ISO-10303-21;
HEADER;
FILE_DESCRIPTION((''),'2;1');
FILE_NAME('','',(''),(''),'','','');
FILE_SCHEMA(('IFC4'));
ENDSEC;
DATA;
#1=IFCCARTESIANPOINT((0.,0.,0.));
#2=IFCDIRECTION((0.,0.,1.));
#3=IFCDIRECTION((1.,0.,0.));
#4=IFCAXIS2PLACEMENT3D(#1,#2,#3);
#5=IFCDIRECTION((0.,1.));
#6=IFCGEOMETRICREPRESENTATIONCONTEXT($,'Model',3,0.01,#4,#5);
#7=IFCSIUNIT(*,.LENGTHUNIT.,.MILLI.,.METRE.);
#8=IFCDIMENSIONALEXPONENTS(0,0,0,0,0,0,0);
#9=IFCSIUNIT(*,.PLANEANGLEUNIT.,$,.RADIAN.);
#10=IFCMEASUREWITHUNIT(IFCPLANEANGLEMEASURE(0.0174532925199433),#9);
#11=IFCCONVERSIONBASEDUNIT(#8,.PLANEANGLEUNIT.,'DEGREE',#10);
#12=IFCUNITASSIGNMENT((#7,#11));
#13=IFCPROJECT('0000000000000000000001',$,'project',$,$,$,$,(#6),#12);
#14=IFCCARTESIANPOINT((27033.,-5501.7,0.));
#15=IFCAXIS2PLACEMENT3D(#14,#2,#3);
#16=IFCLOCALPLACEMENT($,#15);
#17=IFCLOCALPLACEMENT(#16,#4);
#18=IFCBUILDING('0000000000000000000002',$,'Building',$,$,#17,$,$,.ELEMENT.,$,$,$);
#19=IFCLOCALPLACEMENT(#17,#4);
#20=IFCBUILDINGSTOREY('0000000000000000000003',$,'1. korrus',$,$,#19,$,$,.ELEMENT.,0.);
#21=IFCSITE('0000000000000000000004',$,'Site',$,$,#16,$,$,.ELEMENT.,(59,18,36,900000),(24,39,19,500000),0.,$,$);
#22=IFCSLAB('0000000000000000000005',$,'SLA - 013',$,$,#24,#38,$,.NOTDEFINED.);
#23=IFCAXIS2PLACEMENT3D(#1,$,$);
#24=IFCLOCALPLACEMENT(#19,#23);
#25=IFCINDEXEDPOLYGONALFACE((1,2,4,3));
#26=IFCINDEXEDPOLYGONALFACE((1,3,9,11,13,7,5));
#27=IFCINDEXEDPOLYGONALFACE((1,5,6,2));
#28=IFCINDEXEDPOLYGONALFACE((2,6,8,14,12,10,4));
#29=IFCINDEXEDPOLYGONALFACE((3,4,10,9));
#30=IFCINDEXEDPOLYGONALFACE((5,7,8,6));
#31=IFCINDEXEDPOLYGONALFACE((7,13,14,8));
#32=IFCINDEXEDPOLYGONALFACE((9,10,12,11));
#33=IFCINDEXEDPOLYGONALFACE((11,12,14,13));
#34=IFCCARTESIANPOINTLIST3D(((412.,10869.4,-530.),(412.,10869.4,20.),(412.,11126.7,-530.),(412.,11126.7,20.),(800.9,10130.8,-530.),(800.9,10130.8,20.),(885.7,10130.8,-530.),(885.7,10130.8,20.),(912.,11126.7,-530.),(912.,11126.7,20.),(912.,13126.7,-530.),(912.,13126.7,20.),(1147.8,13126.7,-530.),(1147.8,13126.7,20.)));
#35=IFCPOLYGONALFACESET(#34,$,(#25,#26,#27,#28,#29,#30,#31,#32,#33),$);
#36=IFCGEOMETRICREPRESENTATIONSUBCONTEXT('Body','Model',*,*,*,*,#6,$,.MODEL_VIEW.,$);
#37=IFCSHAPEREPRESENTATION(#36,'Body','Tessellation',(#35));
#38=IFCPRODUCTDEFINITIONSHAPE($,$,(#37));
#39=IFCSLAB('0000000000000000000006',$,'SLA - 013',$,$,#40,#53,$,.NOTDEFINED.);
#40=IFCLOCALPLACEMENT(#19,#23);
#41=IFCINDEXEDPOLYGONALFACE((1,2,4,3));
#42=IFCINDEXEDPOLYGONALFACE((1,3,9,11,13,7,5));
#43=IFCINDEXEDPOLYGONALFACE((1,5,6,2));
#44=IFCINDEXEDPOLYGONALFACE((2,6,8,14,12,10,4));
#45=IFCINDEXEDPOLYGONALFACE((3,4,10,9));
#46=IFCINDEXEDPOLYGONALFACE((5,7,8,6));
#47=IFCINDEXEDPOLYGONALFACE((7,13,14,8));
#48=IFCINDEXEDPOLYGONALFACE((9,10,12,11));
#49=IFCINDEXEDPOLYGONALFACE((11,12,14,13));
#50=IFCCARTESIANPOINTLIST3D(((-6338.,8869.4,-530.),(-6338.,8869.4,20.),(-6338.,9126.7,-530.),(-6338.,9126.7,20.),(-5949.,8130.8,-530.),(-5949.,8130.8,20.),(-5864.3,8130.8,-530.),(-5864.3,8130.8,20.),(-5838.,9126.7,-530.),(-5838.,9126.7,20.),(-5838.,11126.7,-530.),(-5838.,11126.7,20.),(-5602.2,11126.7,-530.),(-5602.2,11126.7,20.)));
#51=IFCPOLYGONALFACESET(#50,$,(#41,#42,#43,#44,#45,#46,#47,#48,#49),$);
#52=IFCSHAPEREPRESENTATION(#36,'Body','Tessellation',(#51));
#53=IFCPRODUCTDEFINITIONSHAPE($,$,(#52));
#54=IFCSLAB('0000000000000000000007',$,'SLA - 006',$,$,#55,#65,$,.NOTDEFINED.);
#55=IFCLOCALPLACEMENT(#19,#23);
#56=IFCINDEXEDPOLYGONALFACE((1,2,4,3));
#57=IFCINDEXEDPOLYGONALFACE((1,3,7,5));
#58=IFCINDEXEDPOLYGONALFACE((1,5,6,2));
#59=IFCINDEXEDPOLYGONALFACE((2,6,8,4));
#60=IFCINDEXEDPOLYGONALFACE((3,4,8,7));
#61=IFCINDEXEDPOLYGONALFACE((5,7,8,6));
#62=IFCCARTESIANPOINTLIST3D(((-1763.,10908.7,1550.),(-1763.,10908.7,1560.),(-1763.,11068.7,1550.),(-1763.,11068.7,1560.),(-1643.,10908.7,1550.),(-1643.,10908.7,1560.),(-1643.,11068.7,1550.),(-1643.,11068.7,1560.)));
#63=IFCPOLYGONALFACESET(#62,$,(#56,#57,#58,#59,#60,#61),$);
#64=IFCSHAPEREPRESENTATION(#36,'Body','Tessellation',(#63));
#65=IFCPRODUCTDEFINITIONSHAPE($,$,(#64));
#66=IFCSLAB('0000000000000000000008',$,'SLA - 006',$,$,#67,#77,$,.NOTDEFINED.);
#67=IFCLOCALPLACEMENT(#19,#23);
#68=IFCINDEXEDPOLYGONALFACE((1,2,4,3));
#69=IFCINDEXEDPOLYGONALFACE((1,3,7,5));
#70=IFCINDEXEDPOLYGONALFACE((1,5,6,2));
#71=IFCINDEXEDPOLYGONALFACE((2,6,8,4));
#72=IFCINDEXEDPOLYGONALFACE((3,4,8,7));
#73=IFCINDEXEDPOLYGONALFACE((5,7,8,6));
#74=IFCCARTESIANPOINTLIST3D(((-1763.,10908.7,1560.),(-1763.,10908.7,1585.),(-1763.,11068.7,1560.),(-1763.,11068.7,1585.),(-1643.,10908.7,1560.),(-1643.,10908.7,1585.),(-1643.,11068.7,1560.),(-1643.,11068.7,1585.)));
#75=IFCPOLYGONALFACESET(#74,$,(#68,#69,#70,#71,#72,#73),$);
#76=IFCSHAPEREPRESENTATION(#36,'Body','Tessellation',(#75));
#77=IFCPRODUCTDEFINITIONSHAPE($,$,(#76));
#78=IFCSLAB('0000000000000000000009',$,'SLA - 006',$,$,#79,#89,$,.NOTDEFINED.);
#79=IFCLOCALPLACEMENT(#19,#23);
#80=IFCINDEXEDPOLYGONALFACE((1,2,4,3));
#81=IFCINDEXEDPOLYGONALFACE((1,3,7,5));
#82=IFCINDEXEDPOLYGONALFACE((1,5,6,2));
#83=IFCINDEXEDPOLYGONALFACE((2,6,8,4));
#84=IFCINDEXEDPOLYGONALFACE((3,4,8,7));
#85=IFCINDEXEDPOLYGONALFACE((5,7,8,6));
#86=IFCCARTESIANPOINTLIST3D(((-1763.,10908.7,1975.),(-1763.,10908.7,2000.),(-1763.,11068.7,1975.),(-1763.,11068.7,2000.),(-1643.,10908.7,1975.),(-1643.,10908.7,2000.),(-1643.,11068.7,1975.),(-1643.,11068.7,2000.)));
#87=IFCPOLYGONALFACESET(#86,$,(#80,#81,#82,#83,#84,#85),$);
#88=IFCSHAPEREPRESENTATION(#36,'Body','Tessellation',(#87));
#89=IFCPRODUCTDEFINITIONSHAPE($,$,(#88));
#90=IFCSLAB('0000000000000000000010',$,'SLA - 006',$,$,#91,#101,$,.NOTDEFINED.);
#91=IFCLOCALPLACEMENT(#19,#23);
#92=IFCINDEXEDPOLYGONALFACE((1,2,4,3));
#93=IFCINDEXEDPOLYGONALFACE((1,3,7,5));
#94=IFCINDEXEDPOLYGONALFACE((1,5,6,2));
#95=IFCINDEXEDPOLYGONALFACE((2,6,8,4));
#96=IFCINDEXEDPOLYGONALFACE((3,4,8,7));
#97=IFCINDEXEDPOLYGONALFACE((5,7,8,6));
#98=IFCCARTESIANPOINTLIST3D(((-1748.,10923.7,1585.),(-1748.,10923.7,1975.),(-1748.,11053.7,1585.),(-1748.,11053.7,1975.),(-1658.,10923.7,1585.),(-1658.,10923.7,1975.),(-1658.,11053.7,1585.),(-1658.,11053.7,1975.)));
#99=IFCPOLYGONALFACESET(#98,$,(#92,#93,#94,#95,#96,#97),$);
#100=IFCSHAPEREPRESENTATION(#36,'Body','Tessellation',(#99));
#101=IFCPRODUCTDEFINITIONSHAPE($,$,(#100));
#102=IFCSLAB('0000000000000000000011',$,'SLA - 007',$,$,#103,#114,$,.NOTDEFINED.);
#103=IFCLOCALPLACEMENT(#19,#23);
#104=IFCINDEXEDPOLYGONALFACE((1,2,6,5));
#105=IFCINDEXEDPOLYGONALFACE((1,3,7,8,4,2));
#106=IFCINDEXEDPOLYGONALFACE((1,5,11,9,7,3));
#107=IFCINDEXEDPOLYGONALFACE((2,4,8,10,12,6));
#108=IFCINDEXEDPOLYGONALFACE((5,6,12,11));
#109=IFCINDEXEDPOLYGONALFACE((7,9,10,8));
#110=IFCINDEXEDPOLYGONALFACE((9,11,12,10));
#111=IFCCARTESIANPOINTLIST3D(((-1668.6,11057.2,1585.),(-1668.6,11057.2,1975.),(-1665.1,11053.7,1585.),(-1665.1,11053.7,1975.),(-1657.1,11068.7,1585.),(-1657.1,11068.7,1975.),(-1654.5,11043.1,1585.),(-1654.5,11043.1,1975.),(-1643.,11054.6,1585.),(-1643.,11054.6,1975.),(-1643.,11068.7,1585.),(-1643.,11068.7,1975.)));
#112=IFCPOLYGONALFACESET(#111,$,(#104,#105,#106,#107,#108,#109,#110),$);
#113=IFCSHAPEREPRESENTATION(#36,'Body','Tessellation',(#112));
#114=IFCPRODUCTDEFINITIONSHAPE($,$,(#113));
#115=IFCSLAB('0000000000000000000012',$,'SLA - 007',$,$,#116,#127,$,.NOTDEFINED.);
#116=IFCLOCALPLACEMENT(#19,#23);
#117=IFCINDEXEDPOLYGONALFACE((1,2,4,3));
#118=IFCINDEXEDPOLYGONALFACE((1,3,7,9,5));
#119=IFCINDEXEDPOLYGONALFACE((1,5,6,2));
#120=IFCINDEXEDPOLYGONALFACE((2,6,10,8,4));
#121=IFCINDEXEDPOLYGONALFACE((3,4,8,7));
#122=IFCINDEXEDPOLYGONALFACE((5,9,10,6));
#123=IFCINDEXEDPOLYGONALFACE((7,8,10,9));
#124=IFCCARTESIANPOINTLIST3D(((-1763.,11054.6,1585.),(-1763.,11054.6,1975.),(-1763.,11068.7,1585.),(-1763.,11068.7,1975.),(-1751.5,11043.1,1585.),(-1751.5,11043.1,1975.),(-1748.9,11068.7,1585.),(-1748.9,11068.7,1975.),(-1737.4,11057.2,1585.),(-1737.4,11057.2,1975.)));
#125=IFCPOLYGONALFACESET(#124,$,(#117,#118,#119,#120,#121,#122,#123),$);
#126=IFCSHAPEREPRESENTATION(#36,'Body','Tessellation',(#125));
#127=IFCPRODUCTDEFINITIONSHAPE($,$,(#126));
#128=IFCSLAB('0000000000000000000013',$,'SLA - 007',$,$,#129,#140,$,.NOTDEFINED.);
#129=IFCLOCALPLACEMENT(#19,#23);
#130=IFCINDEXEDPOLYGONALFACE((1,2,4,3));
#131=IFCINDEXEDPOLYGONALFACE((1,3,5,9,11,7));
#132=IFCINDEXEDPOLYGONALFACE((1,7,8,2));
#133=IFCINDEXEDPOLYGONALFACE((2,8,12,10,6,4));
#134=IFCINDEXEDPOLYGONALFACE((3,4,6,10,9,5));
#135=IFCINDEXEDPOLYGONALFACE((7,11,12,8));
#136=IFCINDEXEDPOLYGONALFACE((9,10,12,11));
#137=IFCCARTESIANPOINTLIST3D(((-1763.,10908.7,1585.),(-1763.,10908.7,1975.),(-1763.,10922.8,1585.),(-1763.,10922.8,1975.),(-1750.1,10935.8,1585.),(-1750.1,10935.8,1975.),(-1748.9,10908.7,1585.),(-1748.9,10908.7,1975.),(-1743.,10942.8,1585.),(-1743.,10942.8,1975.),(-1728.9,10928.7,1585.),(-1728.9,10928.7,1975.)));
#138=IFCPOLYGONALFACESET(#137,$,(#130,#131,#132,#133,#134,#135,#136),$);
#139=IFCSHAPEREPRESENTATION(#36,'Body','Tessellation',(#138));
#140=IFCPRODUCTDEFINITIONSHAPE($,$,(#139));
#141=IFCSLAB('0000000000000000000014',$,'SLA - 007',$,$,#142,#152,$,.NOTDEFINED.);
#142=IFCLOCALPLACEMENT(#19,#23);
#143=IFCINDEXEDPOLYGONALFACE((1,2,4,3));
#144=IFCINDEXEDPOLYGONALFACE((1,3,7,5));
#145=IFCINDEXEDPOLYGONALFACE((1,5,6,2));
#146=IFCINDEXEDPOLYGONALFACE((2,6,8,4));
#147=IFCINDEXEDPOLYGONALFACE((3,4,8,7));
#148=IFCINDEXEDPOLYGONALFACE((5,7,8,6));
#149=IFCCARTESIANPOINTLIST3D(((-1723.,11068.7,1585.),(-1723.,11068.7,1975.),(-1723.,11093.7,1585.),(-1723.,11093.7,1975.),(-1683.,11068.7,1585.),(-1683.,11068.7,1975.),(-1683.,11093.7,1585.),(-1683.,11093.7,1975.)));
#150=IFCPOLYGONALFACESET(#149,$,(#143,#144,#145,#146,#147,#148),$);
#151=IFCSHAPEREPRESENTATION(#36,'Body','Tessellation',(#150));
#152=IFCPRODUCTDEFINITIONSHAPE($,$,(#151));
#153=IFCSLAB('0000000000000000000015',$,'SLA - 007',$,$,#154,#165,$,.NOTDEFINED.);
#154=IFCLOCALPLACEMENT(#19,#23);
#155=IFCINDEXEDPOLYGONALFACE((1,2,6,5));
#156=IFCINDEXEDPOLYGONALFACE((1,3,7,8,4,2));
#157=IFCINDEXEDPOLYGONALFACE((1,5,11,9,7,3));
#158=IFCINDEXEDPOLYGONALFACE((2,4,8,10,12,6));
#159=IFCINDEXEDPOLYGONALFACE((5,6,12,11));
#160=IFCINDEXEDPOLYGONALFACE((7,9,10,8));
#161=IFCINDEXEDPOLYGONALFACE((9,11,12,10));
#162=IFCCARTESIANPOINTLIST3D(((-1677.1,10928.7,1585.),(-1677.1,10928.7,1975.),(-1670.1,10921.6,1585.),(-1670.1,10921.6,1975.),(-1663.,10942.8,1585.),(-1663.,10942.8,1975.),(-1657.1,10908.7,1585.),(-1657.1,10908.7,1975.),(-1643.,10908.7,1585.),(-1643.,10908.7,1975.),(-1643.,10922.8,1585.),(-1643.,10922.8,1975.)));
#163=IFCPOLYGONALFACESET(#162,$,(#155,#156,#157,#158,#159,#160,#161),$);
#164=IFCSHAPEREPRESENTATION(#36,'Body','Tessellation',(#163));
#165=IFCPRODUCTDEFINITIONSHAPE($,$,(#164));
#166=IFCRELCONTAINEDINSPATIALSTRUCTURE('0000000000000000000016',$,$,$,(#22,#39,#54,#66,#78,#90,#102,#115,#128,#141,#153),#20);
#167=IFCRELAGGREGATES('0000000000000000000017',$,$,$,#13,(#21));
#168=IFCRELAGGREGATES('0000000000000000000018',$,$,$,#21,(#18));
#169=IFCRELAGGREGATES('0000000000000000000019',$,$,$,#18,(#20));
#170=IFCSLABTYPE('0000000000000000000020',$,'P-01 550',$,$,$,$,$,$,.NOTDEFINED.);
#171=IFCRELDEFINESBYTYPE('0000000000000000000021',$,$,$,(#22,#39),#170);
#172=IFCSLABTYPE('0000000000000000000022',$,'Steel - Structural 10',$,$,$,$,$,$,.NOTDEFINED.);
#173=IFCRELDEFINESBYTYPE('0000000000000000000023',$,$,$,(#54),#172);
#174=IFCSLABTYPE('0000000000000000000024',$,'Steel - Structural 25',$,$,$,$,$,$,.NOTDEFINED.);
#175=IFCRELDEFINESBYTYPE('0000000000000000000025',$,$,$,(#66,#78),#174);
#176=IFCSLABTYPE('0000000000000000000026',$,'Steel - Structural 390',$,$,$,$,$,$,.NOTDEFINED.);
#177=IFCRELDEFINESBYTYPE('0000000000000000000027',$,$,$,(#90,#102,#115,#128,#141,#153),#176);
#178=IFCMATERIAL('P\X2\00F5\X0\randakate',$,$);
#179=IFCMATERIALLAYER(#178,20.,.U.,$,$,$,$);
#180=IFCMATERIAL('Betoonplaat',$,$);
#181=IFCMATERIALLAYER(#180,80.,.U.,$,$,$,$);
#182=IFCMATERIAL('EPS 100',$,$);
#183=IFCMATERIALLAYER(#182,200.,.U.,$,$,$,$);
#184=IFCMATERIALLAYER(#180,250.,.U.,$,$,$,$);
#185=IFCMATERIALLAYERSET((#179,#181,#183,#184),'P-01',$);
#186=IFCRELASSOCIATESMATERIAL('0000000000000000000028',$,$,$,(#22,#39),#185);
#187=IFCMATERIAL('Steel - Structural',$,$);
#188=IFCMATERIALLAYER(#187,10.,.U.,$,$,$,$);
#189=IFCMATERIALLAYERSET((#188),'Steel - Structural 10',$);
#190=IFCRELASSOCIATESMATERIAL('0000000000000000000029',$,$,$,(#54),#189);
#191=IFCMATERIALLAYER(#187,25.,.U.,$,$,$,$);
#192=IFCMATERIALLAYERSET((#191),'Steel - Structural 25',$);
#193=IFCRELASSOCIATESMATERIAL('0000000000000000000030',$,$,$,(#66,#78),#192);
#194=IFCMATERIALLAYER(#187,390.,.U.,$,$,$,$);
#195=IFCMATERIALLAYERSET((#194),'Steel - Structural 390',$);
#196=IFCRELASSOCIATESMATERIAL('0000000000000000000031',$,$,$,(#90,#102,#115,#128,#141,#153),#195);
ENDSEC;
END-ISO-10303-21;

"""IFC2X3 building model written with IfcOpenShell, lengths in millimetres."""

from ifc_helpers import new_model, entity, si_unit, converted_unit, direction, frame, origin_with_axes, place, context, subcontext, project, spatial, polyline, outline, extrude, material, layer, layer_set, layer_usage, type_object, element, save


model = new_model("IFC2X3")

# Units and contexts
model_context = context("Model", 3, precision=0.01, world=origin_with_axes(), true_north=direction((0.0, 1.0)))
body_context = subcontext(model_context, "Body", "Model", "MODEL_VIEW")
ifc_project = project(units=[si_unit("LENGTHUNIT", "METRE", prefix="MILLI"), converted_unit("PLANEANGLEUNIT", "DEGREE", entity("IfcPlaneAngleMeasure", 0.0174532925199433), si_unit("PLANEANGLEUNIT", "RADIAN"), dimensions=[0, 0, 0, 0, 0, 0, 0])], contexts=[model_context])

# Site, building, storey
site_placement = place(None, frame((27033.0, -5501.7, 0.0), z_axis=(0.0, 0.0, 1.0), x_axis=(1.0, 0.0, 0.0)))
site = spatial("IfcSite", under=ifc_project, at=site_placement, Name="Site", CompositionType="ELEMENT", RefLatitude=(59, 18, 36, 900000), RefLongitude=(24, 39, 19, 500000), RefElevation=0.0)
building_placement = place(site_placement, origin_with_axes())
building = spatial("IfcBuilding", under=site, at=building_placement, Name="Building", CompositionType="ELEMENT")
storey_placement = place(building_placement, origin_with_axes())
storey = spatial("IfcBuildingStorey", under=building, at=storey_placement, Name="1. korrus", CompositionType="ELEMENT", Elevation=0.0)

# Slabs
ifc_material_1 = material(Name="Põrandakate")
ifc_layer_1 = layer(ifc_material_1, 20.0, ventilated="UNKNOWN")
ifc_material_2 = material(Name="Betoonplaat")
ifc_layer_2 = layer(ifc_material_2, 80.0, ventilated="UNKNOWN")
ifc_material_3 = material(Name="EPS 100")
ifc_layer_3 = layer(ifc_material_3, 200.0, ventilated="UNKNOWN")
ifc_layer_4 = layer(ifc_material_2, 250.0, ventilated="UNKNOWN")
ifc_layer_set_1 = layer_set([ifc_layer_1, ifc_layer_2, ifc_layer_3, ifc_layer_4], Name="P-01")
ifc_layer_usage_1 = layer_usage(ifc_layer_set_1, "AXIS3", "NEGATIVE", 550.0)
slab_type_1 = type_object("IfcSlabType", Name="P-01 550", PredefinedType="NOTDEFINED")
slab_1_placement = place(storey_placement, frame((412.0, 10869.4, 0.0), z_axis=(0.0, 0.0, 1.0), x_axis=(1.0, 0.0, 0.0)))
element("IfcSlab", 1, at=slab_1_placement, inside=storey, type_object=slab_type_1, material=ifc_layer_usage_1, Name="SLA - 013", PredefinedType="NOTDEFINED", context=body_context, shape_type="SweptSolid", body=[
    extrude(outline(polyline([(0.0, 0.0), (389.0, -738.6), (473.7, -738.6), (735.8, 2257.3), (500.1, 2257.3), (500.0, 257.3), (0.0, 257.3), (0.0, 0.0)])), frame((0.0, 0.0, -530.0), z_axis=(0.0, 0.0, 1.0), x_axis=(1.0, 0.0, 0.0)), (0.0, 0.0, 1.0), 550.0),
])
ifc_layer_usage_2 = layer_usage(ifc_layer_set_1, "AXIS3", "NEGATIVE", 550.0)
slab_2_placement = place(storey_placement, frame((-5838.0, 9126.7, 0.0), z_axis=(0.0, 0.0, 1.0), x_axis=(1.0, 0.0, 0.0)))
element("IfcSlab", 2, at=slab_2_placement, inside=storey, type_object=slab_type_1, material=ifc_layer_usage_2, Name="SLA - 013", PredefinedType="NOTDEFINED", context=body_context, shape_type="SweptSolid", body=[
    extrude(outline(polyline([(0.0, 0.0), (-500.0, 0.0), (-500.0, -257.3), (-111.0, -995.9), (-26.3, -995.9), (235.8, 2000.0), (0.0, 2000.0), (0.0, 0.0)])), frame((0.0, 0.0, -530.0), z_axis=(0.0, 0.0, 1.0), x_axis=(1.0, 0.0, 0.0)), (0.0, 0.0, 1.0), 550.0),
])
ifc_material_4 = material(Name="Steel - Structural")
ifc_layer_5 = layer(ifc_material_4, 10.0, ventilated="UNKNOWN")
ifc_layer_set_2 = layer_set([ifc_layer_5], Name="Steel - Structural 10")
ifc_layer_usage_3 = layer_usage(ifc_layer_set_2, "AXIS3", "NEGATIVE", 10.0)
slab_type_2 = type_object("IfcSlabType", Name="Steel - Structural 10", PredefinedType="NOTDEFINED")
slab_3_placement = place(storey_placement, frame((-1643.0, 11068.7, 1550.0), z_axis=(0.0, 0.0, 1.0), x_axis=(1.0, 0.0, 0.0)))
element("IfcSlab", 3, at=slab_3_placement, inside=storey, type_object=slab_type_2, material=ifc_layer_usage_3, Name="SLA - 006", PredefinedType="NOTDEFINED", context=body_context, shape_type="SweptSolid", body=[
    extrude(outline(polyline([(0.0, 0.0), (-120.0, 0.0), (-120.0, -160.0), (0.0, -160.0), (0.0, 0.0)])), origin_with_axes(), (0.0, 0.0, 1.0), 10.0),
])
ifc_layer_6 = layer(ifc_material_4, 25.0, ventilated="UNKNOWN")
ifc_layer_set_3 = layer_set([ifc_layer_6], Name="Steel - Structural 25")
ifc_layer_usage_4 = layer_usage(ifc_layer_set_3, "AXIS3", "NEGATIVE", 25.0)
slab_type_3 = type_object("IfcSlabType", Name="Steel - Structural 25", PredefinedType="NOTDEFINED")
slab_4_placement = place(storey_placement, frame((-1643.0, 11068.7, 1560.0), z_axis=(0.0, 0.0, 1.0), x_axis=(1.0, 0.0, 0.0)))
element("IfcSlab", 4, at=slab_4_placement, inside=storey, type_object=slab_type_3, material=ifc_layer_usage_4, Name="SLA - 006", PredefinedType="NOTDEFINED", context=body_context, shape_type="SweptSolid", body=[
    extrude(outline(polyline([(0.0, 0.0), (-120.0, 0.0), (-120.0, -160.0), (0.0, -160.0), (0.0, 0.0)])), origin_with_axes(), (0.0, 0.0, 1.0), 25.0),
])
ifc_layer_usage_5 = layer_usage(ifc_layer_set_3, "AXIS3", "NEGATIVE", 25.0)
slab_5_placement = place(storey_placement, frame((-1643.0, 11068.7, 2000.0), z_axis=(0.0, 0.0, 1.0), x_axis=(1.0, 0.0, 0.0)))
element("IfcSlab", 5, at=slab_5_placement, inside=storey, type_object=slab_type_3, material=ifc_layer_usage_5, Name="SLA - 006", PredefinedType="NOTDEFINED", context=body_context, shape_type="SweptSolid", body=[
    extrude(outline(polyline([(0.0, 0.0), (-120.0, 0.0), (-120.0, -160.0), (0.0, -160.0), (0.0, 0.0)])), frame((0.0, 0.0, -25.0), z_axis=(0.0, 0.0, 1.0), x_axis=(1.0, 0.0, 0.0)), (0.0, 0.0, 1.0), 25.0),
])
ifc_layer_7 = layer(ifc_material_4, 390.0, ventilated="UNKNOWN")
ifc_layer_set_4 = layer_set([ifc_layer_7], Name="Steel - Structural 390")
ifc_layer_usage_6 = layer_usage(ifc_layer_set_4, "AXIS3", "NEGATIVE", 390.0)
slab_type_4 = type_object("IfcSlabType", Name="Steel - Structural 390", PredefinedType="NOTDEFINED")
slab_6_placement = place(storey_placement, frame((-1658.0, 11053.7, 1585.0), z_axis=(0.0, 0.0, 1.0), x_axis=(1.0, 0.0, 0.0)))
element("IfcSlab", 6, at=slab_6_placement, inside=storey, type_object=slab_type_4, material=ifc_layer_usage_6, Name="SLA - 006", PredefinedType="NOTDEFINED", context=body_context, shape_type="SweptSolid", body=[
    extrude(outline(polyline([(0.0, 0.0), (-90.0, 0.0), (-90.0, -130.0), (0.0, -130.0), (0.0, 0.0)])), origin_with_axes(), (0.0, 0.0, 1.0), 390.0),
])
ifc_layer_usage_7 = layer_usage(ifc_layer_set_4, "AXIS3", "NEGATIVE", 390.0)
slab_7_placement = place(storey_placement, frame((-1657.1, 11068.7, 1585.0), z_axis=(0.0, 0.0, 1.0), x_axis=(1.0, 0.0, 0.0)))
element("IfcSlab", 7, at=slab_7_placement, inside=storey, type_object=slab_type_4, material=ifc_layer_usage_7, Name="SLA - 007", PredefinedType="NOTDEFINED", context=body_context, shape_type="SweptSolid", body=[
    extrude(outline(polyline([(0.0, 0.0), (-11.5, -11.5), (-7.9, -15.0), (2.7, -25.6), (14.1, -14.1), (14.1, 0.0), (0.0, 0.0)])), origin_with_axes(), (0.0, 0.0, 1.0), 390.0),
])
ifc_layer_usage_8 = layer_usage(ifc_layer_set_4, "AXIS3", "NEGATIVE", 390.0)
slab_8_placement = place(storey_placement, frame((-1751.5, 11043.1, 1585.0), z_axis=(0.0, 0.0, 1.0), x_axis=(1.0, 0.0, 0.0)))
element("IfcSlab", 8, at=slab_8_placement, inside=storey, type_object=slab_type_4, material=ifc_layer_usage_8, Name="SLA - 007", PredefinedType="NOTDEFINED", context=body_context, shape_type="SweptSolid", body=[
    extrude(outline(polyline([(0.0, 0.0), (14.1, 14.1), (2.7, 25.6), (-11.5, 25.6), (-11.5, 11.5), (0.0, 0.0)])), origin_with_axes(), (0.0, 0.0, 1.0), 390.0),
])
ifc_layer_usage_9 = layer_usage(ifc_layer_set_4, "AXIS3", "NEGATIVE", 390.0)
slab_9_placement = place(storey_placement, frame((-1750.1, 10935.8, 1585.0), z_axis=(0.0, 0.0, 1.0), x_axis=(1.0, 0.0, 0.0)))
element("IfcSlab", 9, at=slab_9_placement, inside=storey, type_object=slab_type_4, material=ifc_layer_usage_9, Name="SLA - 007", PredefinedType="NOTDEFINED", context=body_context, shape_type="SweptSolid", body=[
    extrude(outline(polyline([(0.0, 0.0), (-12.9, -12.9), (-12.9, -27.1), (1.2, -27.1), (21.2, -7.1), (7.1, 7.1), (0.0, 0.0)])), origin_with_axes(), (0.0, 0.0, 1.0), 390.0),
])
ifc_layer_usage_10 = layer_usage(ifc_layer_set_4, "AXIS3", "NEGATIVE", 390.0)
slab_10_placement = place(storey_placement, frame((-1723.0, 11068.7, 1585.0), z_axis=(0.0, 0.0, 1.0), x_axis=(1.0, 0.0, 0.0)))
element("IfcSlab", 10, at=slab_10_placement, inside=storey, type_object=slab_type_4, material=ifc_layer_usage_10, Name="SLA - 007", PredefinedType="NOTDEFINED", context=body_context, shape_type="SweptSolid", body=[
    extrude(outline(polyline([(0.0, 0.0), (40.0, 0.0), (40.0, 25.0), (0.0, 25.0), (0.0, 0.0)])), origin_with_axes(), (0.0, 0.0, 1.0), 390.0),
])
ifc_layer_usage_11 = layer_usage(ifc_layer_set_4, "AXIS3", "NEGATIVE", 390.0)
slab_11_placement = place(storey_placement, frame((-1670.1, 10921.6, 1585.0), z_axis=(0.0, 0.0, 1.0), x_axis=(1.0, 0.0, 0.0)))
element("IfcSlab", 11, at=slab_11_placement, inside=storey, type_object=slab_type_4, material=ifc_layer_usage_11, Name="SLA - 007", PredefinedType="NOTDEFINED", context=body_context, shape_type="SweptSolid", body=[
    extrude(outline(polyline([(0.0, 0.0), (12.9, -12.9), (27.1, -12.9), (27.1, 1.2), (7.1, 21.2), (-7.1, 7.1), (0.0, 0.0)])), origin_with_axes(), (0.0, 0.0, 1.0), 390.0),
])

save(model, "model.ifc")
